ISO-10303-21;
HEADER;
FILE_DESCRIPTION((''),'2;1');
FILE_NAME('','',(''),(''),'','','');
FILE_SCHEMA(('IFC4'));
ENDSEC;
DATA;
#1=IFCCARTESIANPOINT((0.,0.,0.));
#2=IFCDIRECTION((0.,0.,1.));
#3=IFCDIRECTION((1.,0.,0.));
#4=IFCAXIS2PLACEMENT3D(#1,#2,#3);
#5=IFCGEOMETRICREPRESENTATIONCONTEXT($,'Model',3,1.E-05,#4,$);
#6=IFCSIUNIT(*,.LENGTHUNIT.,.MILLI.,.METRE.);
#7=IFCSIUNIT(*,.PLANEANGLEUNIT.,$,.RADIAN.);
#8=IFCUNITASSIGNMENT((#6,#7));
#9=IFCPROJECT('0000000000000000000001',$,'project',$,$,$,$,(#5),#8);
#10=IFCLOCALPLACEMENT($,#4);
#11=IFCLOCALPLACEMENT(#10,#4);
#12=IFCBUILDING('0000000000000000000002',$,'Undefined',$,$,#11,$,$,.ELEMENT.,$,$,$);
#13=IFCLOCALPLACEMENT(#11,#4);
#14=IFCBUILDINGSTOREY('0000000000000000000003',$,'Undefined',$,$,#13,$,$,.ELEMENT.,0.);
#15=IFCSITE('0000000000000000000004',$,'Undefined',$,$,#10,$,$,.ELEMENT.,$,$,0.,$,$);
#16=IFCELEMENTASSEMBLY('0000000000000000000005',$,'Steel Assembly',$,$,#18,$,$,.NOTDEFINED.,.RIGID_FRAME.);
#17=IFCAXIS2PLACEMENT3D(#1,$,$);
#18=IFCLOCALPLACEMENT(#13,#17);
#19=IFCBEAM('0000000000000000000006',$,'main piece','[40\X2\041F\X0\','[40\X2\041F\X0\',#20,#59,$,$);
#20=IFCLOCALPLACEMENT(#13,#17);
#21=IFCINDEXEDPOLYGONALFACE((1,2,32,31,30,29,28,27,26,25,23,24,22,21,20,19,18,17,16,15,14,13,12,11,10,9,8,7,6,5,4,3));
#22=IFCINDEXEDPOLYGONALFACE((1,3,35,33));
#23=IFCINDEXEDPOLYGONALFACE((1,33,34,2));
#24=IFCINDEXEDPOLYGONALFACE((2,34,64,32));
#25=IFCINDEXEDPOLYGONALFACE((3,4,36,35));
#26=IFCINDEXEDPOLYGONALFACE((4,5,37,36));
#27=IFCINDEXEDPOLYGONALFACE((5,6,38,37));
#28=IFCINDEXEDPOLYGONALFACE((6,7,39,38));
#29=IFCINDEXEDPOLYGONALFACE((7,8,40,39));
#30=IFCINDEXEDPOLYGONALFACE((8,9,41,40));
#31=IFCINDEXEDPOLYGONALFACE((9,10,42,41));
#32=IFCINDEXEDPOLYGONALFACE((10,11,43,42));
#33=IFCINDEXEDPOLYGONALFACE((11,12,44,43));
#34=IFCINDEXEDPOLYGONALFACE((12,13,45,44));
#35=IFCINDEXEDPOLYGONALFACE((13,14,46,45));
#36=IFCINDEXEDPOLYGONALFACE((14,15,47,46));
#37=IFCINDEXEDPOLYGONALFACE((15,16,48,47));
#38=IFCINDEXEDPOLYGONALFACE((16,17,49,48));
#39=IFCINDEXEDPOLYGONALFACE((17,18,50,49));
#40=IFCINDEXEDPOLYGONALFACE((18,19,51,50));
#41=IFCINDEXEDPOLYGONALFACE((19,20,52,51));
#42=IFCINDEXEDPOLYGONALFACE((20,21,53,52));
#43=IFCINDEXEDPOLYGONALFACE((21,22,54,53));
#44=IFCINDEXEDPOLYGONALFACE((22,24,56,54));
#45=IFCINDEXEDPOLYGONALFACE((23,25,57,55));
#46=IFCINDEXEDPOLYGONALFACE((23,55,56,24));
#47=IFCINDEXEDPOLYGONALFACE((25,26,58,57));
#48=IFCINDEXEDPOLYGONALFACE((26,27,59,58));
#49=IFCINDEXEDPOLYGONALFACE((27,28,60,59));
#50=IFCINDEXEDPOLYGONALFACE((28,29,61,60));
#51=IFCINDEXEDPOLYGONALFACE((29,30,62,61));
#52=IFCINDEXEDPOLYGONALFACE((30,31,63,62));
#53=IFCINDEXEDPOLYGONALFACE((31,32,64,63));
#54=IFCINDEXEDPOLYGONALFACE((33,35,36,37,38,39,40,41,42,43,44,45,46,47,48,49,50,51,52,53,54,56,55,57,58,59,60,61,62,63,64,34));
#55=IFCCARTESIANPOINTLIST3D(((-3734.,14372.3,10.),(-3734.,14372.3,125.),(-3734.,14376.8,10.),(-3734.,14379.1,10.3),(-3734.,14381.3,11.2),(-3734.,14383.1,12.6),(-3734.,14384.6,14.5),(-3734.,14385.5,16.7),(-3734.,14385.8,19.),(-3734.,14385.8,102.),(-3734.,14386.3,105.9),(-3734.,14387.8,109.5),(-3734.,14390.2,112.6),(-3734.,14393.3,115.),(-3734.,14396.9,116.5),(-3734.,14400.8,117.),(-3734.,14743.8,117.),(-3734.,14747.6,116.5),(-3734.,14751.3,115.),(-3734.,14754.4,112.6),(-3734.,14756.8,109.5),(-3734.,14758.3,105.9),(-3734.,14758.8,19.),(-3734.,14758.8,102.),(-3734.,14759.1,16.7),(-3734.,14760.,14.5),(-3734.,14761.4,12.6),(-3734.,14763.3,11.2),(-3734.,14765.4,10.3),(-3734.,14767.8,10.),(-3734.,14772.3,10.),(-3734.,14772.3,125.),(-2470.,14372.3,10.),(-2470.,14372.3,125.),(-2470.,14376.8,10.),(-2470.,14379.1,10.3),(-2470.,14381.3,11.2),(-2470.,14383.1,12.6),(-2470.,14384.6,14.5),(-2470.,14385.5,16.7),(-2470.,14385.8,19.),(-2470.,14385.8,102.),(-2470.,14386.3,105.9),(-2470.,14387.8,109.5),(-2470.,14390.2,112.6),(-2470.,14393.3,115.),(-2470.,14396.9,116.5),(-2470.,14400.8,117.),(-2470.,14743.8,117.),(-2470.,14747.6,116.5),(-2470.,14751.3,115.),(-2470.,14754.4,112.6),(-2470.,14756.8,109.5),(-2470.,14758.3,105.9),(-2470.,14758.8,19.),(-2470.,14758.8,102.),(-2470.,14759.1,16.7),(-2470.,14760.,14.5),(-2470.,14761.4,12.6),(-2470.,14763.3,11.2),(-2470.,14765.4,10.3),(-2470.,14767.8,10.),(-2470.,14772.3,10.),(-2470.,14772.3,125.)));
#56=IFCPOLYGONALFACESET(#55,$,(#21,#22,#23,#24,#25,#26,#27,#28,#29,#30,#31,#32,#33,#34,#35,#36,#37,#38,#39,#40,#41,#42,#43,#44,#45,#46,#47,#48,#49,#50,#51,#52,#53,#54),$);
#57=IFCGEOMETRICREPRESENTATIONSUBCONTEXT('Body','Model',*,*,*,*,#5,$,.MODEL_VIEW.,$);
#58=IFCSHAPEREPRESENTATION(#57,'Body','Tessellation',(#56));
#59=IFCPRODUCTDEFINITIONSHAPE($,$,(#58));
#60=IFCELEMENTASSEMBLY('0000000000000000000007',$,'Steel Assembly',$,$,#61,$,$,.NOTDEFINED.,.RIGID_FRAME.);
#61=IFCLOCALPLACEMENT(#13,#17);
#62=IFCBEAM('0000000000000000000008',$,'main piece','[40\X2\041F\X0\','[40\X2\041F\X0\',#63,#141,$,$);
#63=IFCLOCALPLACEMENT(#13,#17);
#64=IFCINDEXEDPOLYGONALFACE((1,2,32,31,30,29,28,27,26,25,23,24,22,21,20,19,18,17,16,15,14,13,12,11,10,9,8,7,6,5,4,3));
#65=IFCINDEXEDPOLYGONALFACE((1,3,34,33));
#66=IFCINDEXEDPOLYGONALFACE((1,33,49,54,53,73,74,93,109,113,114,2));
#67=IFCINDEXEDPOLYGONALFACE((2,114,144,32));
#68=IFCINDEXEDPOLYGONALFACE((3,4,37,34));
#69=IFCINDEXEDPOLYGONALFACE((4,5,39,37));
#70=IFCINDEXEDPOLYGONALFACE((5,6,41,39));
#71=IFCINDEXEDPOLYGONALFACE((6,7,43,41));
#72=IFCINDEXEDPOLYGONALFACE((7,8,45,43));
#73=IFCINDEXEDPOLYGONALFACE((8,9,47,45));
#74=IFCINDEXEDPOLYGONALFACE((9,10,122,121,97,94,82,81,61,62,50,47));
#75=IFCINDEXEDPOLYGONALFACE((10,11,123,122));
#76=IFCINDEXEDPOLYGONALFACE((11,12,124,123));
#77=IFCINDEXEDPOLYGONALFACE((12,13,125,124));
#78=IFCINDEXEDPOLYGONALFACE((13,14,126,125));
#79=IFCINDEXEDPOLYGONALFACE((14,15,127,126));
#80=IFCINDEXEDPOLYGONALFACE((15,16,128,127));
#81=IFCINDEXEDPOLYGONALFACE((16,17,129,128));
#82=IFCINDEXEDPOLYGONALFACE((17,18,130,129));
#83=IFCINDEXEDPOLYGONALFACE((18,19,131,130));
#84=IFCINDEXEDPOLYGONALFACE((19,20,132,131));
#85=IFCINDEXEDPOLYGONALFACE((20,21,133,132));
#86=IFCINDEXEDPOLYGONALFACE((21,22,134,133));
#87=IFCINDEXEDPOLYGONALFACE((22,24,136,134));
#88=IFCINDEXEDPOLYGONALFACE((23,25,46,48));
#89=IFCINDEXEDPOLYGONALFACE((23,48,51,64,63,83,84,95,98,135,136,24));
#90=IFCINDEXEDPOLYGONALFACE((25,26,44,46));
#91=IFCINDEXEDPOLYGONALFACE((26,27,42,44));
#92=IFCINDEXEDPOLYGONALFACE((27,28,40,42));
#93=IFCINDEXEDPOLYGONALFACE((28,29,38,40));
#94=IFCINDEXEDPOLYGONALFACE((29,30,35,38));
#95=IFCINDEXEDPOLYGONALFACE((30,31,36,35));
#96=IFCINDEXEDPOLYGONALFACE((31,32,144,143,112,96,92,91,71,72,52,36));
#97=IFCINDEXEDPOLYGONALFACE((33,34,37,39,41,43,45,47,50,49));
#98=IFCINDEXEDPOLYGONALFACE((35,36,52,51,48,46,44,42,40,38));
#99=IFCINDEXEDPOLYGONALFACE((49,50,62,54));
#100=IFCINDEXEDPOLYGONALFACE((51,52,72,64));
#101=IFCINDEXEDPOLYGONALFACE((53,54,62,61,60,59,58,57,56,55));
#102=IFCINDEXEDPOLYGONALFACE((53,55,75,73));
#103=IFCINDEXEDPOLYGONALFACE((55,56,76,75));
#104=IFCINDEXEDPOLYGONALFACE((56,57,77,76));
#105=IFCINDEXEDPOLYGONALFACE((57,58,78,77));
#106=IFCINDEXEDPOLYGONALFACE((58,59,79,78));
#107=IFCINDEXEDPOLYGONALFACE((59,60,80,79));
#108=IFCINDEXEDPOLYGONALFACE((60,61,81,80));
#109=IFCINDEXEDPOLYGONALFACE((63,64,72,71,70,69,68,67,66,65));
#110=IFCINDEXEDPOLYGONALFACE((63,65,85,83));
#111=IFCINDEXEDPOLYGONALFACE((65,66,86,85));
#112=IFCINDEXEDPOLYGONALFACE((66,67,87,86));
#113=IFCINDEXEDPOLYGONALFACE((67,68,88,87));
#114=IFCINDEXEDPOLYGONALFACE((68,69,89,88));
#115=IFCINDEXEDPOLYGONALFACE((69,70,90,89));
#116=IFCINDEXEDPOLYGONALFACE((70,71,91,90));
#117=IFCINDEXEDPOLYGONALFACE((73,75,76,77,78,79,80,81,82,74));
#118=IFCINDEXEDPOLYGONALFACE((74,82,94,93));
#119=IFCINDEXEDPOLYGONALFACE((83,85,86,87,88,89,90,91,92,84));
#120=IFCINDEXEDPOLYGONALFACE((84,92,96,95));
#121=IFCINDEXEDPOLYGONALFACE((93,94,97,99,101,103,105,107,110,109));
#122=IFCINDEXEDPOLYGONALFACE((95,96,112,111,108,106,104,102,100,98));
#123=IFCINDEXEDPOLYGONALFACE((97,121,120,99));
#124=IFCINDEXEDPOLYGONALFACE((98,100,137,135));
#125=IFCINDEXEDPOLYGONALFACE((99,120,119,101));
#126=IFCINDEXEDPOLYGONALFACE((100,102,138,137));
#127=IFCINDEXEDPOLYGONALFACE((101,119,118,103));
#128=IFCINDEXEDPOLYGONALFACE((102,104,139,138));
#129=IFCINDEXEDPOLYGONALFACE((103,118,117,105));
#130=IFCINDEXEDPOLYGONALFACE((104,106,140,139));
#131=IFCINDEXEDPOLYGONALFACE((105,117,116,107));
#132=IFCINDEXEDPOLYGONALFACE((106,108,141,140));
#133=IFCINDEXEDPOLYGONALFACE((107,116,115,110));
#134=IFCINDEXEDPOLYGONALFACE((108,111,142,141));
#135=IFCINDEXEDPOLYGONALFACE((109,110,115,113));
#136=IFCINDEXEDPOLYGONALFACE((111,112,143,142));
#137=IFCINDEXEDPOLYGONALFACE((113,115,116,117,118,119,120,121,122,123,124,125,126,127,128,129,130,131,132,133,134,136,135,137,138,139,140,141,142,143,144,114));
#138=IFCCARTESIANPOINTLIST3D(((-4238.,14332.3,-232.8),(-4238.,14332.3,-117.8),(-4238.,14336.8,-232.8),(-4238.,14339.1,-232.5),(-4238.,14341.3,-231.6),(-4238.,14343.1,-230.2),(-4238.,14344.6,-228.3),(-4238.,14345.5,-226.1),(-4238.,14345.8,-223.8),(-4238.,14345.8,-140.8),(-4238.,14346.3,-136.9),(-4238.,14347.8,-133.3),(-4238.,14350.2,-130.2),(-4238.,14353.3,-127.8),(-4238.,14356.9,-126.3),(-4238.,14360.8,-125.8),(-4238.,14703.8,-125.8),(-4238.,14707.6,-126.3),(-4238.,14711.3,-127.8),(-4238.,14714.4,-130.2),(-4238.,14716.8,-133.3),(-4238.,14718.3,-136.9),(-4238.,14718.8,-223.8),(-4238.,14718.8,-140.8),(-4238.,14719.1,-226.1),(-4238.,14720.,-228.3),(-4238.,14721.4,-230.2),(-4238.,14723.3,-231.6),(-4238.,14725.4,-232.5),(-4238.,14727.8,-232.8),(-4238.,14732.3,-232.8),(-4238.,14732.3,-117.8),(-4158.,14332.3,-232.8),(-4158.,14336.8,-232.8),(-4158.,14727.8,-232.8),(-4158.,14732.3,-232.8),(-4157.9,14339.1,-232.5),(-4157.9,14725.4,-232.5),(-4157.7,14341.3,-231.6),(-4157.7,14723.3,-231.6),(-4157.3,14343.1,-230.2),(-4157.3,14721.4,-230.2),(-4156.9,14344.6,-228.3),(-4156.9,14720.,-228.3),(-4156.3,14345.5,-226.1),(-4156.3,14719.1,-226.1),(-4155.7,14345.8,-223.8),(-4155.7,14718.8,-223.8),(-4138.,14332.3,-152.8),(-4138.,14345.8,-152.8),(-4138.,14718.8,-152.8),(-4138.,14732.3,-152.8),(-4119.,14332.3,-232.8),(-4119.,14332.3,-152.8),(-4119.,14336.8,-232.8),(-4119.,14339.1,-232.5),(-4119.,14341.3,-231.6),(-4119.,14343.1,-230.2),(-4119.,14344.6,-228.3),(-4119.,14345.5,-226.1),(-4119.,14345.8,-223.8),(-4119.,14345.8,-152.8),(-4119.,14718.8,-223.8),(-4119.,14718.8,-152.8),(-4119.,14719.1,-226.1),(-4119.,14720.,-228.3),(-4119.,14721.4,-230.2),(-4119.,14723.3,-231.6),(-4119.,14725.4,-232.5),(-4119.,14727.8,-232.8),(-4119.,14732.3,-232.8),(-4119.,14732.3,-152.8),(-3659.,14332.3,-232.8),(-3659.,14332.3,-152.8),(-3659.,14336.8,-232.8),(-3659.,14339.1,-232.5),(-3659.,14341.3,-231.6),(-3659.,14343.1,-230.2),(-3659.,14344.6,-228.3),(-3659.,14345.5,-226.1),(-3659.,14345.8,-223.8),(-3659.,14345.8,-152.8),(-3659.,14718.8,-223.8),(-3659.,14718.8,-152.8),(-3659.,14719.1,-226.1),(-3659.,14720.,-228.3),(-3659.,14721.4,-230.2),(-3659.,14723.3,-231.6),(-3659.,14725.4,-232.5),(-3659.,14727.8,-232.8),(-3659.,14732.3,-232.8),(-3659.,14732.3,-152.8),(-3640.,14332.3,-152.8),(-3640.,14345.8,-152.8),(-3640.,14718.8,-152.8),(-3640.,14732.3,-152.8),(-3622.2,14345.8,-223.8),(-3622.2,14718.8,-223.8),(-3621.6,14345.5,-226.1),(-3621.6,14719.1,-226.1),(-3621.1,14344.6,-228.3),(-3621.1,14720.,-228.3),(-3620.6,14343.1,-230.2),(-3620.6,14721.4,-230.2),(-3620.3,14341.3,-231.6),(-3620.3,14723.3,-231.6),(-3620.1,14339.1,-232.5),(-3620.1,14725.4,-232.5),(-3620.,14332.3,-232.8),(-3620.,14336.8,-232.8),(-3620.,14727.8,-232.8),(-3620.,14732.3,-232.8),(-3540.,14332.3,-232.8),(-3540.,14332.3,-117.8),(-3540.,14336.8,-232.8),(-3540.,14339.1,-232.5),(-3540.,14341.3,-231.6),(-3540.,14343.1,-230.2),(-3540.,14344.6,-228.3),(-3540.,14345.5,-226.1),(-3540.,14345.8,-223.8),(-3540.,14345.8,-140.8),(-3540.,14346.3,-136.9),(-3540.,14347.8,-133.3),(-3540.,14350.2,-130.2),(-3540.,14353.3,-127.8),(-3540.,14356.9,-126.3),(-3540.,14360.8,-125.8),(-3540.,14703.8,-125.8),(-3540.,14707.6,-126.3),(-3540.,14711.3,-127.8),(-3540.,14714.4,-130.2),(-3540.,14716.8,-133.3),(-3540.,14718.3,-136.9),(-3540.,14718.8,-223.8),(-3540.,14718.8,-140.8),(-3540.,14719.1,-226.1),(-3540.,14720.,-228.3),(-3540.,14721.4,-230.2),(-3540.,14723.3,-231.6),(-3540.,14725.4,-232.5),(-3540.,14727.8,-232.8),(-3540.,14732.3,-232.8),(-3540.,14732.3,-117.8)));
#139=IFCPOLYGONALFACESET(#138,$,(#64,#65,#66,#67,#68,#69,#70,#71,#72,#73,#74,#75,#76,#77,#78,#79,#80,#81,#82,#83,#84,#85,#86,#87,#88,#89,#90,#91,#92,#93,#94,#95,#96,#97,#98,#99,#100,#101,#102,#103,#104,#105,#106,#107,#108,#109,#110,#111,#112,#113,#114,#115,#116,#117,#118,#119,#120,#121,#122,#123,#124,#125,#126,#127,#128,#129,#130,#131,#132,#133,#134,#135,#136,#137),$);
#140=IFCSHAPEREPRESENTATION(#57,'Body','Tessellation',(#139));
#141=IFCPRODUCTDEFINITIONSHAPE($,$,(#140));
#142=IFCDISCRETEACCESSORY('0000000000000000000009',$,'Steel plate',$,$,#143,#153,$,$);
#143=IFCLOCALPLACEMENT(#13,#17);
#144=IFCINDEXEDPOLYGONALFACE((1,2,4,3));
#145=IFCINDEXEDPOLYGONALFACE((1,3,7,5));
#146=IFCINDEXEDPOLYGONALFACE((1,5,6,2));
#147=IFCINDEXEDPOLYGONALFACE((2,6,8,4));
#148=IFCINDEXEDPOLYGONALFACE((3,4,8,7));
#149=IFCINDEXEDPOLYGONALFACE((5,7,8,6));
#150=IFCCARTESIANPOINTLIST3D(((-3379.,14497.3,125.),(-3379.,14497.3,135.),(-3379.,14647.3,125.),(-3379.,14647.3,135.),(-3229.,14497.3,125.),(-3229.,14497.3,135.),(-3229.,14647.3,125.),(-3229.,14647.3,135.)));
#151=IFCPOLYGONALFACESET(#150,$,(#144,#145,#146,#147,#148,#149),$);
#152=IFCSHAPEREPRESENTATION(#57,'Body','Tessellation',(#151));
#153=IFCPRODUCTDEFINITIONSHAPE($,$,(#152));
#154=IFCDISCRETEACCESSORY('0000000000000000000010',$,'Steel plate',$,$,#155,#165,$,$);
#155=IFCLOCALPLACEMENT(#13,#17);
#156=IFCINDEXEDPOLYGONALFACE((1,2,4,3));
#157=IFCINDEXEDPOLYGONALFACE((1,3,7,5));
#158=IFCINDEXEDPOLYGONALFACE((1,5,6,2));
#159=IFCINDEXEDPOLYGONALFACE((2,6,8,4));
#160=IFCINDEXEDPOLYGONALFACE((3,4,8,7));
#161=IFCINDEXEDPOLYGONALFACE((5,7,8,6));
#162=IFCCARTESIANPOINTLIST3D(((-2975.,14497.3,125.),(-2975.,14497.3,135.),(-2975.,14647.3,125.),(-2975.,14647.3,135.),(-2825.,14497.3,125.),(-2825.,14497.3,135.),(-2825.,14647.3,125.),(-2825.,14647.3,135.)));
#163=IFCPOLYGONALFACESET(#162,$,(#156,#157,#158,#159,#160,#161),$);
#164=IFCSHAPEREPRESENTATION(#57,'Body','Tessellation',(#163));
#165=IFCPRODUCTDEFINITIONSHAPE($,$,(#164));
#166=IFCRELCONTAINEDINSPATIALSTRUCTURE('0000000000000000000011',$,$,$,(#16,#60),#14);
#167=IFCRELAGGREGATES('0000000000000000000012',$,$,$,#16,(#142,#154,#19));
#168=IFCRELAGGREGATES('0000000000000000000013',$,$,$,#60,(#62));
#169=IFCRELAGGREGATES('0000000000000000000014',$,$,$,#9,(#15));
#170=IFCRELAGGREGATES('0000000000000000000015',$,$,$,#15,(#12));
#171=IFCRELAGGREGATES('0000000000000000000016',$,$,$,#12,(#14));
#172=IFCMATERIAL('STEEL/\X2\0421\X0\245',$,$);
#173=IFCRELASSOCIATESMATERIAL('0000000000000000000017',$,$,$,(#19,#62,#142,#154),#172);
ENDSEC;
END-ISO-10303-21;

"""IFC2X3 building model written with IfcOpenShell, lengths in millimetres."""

from ifc_helpers import new_model, si_unit, frame, origin_with_axes, origin_2d_with_axis, place, context, subcontext, project, spatial, polyline, u_section, outline, extrude, material, element, aggregate, save


model = new_model("IFC2X3")

# Units and contexts
model_context = context("Model", 3, precision=1e-05, world=origin_with_axes())
body_context = subcontext(model_context, "Body", "Model", "MODEL_VIEW")
ifc_project = project(units=[si_unit("LENGTHUNIT", "METRE", prefix="MILLI"), si_unit("PLANEANGLEUNIT", "RADIAN")], contexts=[model_context])

# Site, building, storey
site_placement = place(None, origin_with_axes())
site = spatial("IfcSite", under=ifc_project, at=site_placement, Name="Undefined", CompositionType="ELEMENT", RefElevation=0.0)
building_placement = place(site_placement, origin_with_axes())
building = spatial("IfcBuilding", under=site, at=building_placement, Name="Undefined", CompositionType="ELEMENT")
storey_placement = place(building_placement, origin_with_axes())
storey = spatial("IfcBuildingStorey", under=building, at=storey_placement, Name="Undefined", CompositionType="ELEMENT", Elevation=0.0)

# Element assembly, beam
assembly_1_placement = place(storey_placement, origin_with_axes())
assembly_1 = element("IfcElementAssembly", 1, at=assembly_1_placement, inside=storey, Name="Steel Assembly", AssemblyPlace="NOTDEFINED", PredefinedType="RIGID_FRAME")
ifc_material = material(Name="STEEL/С245")
beam_1_placement = place(assembly_1_placement, frame((-3734.0, 14572.3, 67.5), z_axis=(0.0, -1.0, 0.0), x_axis=(1.0, 0.0, 0.0)))
beam_1 = element("IfcBeam", 2, at=beam_1_placement, material=ifc_material, Name="main piece", Description="[40П", ObjectType="[40П", context=body_context, shape_type="SweptSolid", body=[
    extrude(u_section(Depth=400.0, FlangeWidth=115.0, WebThickness=8.0, FlangeThickness=13.5, FilletRadius=15.0, EdgeRadius=9.0, at=origin_2d_with_axis()), frame((1264.0, 0.0, 0.0), z_axis=(-1.0, 0.0, 0.0), x_axis=(0.0, -1.0, 0.0)), (0.0, 0.0, 1.0), 1264.0),
])

# Element assembly, beam, openings
assembly_2_placement = place(storey_placement, origin_with_axes())
assembly_2 = element("IfcElementAssembly", 3, at=assembly_2_placement, inside=storey, Name="Steel Assembly", AssemblyPlace="NOTDEFINED", PredefinedType="RIGID_FRAME")
beam_2_placement = place(assembly_2_placement, frame((-4238.0, 14532.3, -175.3), z_axis=(0.0, -1.0, 0.0), x_axis=(1.0, 0.0, 0.0)))
beam_2 = element("IfcBeam", 4, at=beam_2_placement, material=ifc_material, Name="main piece", Description="[40П", ObjectType="[40П", context=body_context, shape_type="SweptSolid", body=[
    extrude(u_section(Depth=400.0, FlangeWidth=115.0, WebThickness=8.0, FlangeThickness=13.5, FilletRadius=15.0, EdgeRadius=9.0, at=origin_2d_with_axis()), frame((698.0, 0.0, 0.0), z_axis=(-1.0, 0.0, 0.0), x_axis=(0.0, -1.0, 0.0)), (0.0, 0.0, 1.0), 698.0),
])
opening_1_placement = place(assembly_2_placement, frame((-4238.0, 14532.3, -175.3), z_axis=(0.0, -1.0, 0.0), x_axis=(1.0, 0.0, 0.0)))
element("IfcOpeningElement", 5, at=opening_1_placement, cuts=beam_2, ObjectType="Recess", context=body_context, shape_type="SweptSolid", body=[
    extrude(outline(polyline([(0.0, 0.0), (39.0, 0.0), (39.0, 80.0), (20.0, 80.0), (0.0, 0.0)])), frame((618.0, -57.5, 203.0), z_axis=(0.0, 0.0, -1.0), x_axis=(-1.0, 0.0, 0.0)), (0.0, 0.0, 1.0), 406.0),
])
opening_2_placement = place(assembly_2_placement, frame((-4238.0, 14532.3, -175.3), z_axis=(0.0, -1.0, 0.0), x_axis=(1.0, 0.0, 0.0)))
element("IfcOpeningElement", 6, at=opening_2_placement, cuts=beam_2, ObjectType="Recess", context=body_context, shape_type="SweptSolid", body=[
    extrude(outline(polyline([(0.0, 0.0), (39.0, 0.0), (39.0, 80.0), (20.0, 80.0), (0.0, 0.0)])), frame((80.0, -57.5, -203.0), z_axis=(0.0, 0.0, 1.0), x_axis=(1.0, 0.0, 0.0)), (0.0, 0.0, 1.0), 406.0),
])

# Discrete accessories
discrete_accessory_1_placement = place(assembly_1_placement, frame((-3379.0, 14647.3, 130.0), z_axis=(0.0, 0.0, -1.0), x_axis=(1.0, 0.0, 0.0)))
discrete_accessory_1 = element("IfcDiscreteAccessory", 7, at=discrete_accessory_1_placement, material=ifc_material, Name="Steel plate", context=body_context, shape_type="SweptSolid", body=[
    extrude(outline(polyline([(0.0, 0.0), (150.0, 0.0), (150.0, 150.0), (0.0, 150.0), (0.0, 0.0)])), frame((0.0, 0.0, -5.0), z_axis=(0.0, 0.0, 1.0), x_axis=(1.0, 0.0, 0.0)), (0.0, 0.0, 1.0), 10.0),
])
discrete_accessory_2_placement = place(assembly_1_placement, frame((-2825.0, 14647.3, 130.0), z_axis=(0.0, 0.0, 1.0), x_axis=(-1.0, 0.0, 0.0)))
discrete_accessory_2 = element("IfcDiscreteAccessory", 8, at=discrete_accessory_2_placement, material=ifc_material, Name="Steel plate", context=body_context, shape_type="SweptSolid", body=[
    extrude(outline(polyline([(0.0, 0.0), (150.0, 0.0), (150.0, 150.0), (0.0, 150.0), (0.0, 0.0)])), frame((0.0, 0.0, -5.0), z_axis=(0.0, 0.0, 1.0), x_axis=(1.0, 0.0, 0.0)), (0.0, 0.0, 1.0), 10.0),
])
aggregate(assembly_1, [discrete_accessory_1, discrete_accessory_2, beam_1])
aggregate(assembly_2, [beam_2])

save(model, "model.ifc")
